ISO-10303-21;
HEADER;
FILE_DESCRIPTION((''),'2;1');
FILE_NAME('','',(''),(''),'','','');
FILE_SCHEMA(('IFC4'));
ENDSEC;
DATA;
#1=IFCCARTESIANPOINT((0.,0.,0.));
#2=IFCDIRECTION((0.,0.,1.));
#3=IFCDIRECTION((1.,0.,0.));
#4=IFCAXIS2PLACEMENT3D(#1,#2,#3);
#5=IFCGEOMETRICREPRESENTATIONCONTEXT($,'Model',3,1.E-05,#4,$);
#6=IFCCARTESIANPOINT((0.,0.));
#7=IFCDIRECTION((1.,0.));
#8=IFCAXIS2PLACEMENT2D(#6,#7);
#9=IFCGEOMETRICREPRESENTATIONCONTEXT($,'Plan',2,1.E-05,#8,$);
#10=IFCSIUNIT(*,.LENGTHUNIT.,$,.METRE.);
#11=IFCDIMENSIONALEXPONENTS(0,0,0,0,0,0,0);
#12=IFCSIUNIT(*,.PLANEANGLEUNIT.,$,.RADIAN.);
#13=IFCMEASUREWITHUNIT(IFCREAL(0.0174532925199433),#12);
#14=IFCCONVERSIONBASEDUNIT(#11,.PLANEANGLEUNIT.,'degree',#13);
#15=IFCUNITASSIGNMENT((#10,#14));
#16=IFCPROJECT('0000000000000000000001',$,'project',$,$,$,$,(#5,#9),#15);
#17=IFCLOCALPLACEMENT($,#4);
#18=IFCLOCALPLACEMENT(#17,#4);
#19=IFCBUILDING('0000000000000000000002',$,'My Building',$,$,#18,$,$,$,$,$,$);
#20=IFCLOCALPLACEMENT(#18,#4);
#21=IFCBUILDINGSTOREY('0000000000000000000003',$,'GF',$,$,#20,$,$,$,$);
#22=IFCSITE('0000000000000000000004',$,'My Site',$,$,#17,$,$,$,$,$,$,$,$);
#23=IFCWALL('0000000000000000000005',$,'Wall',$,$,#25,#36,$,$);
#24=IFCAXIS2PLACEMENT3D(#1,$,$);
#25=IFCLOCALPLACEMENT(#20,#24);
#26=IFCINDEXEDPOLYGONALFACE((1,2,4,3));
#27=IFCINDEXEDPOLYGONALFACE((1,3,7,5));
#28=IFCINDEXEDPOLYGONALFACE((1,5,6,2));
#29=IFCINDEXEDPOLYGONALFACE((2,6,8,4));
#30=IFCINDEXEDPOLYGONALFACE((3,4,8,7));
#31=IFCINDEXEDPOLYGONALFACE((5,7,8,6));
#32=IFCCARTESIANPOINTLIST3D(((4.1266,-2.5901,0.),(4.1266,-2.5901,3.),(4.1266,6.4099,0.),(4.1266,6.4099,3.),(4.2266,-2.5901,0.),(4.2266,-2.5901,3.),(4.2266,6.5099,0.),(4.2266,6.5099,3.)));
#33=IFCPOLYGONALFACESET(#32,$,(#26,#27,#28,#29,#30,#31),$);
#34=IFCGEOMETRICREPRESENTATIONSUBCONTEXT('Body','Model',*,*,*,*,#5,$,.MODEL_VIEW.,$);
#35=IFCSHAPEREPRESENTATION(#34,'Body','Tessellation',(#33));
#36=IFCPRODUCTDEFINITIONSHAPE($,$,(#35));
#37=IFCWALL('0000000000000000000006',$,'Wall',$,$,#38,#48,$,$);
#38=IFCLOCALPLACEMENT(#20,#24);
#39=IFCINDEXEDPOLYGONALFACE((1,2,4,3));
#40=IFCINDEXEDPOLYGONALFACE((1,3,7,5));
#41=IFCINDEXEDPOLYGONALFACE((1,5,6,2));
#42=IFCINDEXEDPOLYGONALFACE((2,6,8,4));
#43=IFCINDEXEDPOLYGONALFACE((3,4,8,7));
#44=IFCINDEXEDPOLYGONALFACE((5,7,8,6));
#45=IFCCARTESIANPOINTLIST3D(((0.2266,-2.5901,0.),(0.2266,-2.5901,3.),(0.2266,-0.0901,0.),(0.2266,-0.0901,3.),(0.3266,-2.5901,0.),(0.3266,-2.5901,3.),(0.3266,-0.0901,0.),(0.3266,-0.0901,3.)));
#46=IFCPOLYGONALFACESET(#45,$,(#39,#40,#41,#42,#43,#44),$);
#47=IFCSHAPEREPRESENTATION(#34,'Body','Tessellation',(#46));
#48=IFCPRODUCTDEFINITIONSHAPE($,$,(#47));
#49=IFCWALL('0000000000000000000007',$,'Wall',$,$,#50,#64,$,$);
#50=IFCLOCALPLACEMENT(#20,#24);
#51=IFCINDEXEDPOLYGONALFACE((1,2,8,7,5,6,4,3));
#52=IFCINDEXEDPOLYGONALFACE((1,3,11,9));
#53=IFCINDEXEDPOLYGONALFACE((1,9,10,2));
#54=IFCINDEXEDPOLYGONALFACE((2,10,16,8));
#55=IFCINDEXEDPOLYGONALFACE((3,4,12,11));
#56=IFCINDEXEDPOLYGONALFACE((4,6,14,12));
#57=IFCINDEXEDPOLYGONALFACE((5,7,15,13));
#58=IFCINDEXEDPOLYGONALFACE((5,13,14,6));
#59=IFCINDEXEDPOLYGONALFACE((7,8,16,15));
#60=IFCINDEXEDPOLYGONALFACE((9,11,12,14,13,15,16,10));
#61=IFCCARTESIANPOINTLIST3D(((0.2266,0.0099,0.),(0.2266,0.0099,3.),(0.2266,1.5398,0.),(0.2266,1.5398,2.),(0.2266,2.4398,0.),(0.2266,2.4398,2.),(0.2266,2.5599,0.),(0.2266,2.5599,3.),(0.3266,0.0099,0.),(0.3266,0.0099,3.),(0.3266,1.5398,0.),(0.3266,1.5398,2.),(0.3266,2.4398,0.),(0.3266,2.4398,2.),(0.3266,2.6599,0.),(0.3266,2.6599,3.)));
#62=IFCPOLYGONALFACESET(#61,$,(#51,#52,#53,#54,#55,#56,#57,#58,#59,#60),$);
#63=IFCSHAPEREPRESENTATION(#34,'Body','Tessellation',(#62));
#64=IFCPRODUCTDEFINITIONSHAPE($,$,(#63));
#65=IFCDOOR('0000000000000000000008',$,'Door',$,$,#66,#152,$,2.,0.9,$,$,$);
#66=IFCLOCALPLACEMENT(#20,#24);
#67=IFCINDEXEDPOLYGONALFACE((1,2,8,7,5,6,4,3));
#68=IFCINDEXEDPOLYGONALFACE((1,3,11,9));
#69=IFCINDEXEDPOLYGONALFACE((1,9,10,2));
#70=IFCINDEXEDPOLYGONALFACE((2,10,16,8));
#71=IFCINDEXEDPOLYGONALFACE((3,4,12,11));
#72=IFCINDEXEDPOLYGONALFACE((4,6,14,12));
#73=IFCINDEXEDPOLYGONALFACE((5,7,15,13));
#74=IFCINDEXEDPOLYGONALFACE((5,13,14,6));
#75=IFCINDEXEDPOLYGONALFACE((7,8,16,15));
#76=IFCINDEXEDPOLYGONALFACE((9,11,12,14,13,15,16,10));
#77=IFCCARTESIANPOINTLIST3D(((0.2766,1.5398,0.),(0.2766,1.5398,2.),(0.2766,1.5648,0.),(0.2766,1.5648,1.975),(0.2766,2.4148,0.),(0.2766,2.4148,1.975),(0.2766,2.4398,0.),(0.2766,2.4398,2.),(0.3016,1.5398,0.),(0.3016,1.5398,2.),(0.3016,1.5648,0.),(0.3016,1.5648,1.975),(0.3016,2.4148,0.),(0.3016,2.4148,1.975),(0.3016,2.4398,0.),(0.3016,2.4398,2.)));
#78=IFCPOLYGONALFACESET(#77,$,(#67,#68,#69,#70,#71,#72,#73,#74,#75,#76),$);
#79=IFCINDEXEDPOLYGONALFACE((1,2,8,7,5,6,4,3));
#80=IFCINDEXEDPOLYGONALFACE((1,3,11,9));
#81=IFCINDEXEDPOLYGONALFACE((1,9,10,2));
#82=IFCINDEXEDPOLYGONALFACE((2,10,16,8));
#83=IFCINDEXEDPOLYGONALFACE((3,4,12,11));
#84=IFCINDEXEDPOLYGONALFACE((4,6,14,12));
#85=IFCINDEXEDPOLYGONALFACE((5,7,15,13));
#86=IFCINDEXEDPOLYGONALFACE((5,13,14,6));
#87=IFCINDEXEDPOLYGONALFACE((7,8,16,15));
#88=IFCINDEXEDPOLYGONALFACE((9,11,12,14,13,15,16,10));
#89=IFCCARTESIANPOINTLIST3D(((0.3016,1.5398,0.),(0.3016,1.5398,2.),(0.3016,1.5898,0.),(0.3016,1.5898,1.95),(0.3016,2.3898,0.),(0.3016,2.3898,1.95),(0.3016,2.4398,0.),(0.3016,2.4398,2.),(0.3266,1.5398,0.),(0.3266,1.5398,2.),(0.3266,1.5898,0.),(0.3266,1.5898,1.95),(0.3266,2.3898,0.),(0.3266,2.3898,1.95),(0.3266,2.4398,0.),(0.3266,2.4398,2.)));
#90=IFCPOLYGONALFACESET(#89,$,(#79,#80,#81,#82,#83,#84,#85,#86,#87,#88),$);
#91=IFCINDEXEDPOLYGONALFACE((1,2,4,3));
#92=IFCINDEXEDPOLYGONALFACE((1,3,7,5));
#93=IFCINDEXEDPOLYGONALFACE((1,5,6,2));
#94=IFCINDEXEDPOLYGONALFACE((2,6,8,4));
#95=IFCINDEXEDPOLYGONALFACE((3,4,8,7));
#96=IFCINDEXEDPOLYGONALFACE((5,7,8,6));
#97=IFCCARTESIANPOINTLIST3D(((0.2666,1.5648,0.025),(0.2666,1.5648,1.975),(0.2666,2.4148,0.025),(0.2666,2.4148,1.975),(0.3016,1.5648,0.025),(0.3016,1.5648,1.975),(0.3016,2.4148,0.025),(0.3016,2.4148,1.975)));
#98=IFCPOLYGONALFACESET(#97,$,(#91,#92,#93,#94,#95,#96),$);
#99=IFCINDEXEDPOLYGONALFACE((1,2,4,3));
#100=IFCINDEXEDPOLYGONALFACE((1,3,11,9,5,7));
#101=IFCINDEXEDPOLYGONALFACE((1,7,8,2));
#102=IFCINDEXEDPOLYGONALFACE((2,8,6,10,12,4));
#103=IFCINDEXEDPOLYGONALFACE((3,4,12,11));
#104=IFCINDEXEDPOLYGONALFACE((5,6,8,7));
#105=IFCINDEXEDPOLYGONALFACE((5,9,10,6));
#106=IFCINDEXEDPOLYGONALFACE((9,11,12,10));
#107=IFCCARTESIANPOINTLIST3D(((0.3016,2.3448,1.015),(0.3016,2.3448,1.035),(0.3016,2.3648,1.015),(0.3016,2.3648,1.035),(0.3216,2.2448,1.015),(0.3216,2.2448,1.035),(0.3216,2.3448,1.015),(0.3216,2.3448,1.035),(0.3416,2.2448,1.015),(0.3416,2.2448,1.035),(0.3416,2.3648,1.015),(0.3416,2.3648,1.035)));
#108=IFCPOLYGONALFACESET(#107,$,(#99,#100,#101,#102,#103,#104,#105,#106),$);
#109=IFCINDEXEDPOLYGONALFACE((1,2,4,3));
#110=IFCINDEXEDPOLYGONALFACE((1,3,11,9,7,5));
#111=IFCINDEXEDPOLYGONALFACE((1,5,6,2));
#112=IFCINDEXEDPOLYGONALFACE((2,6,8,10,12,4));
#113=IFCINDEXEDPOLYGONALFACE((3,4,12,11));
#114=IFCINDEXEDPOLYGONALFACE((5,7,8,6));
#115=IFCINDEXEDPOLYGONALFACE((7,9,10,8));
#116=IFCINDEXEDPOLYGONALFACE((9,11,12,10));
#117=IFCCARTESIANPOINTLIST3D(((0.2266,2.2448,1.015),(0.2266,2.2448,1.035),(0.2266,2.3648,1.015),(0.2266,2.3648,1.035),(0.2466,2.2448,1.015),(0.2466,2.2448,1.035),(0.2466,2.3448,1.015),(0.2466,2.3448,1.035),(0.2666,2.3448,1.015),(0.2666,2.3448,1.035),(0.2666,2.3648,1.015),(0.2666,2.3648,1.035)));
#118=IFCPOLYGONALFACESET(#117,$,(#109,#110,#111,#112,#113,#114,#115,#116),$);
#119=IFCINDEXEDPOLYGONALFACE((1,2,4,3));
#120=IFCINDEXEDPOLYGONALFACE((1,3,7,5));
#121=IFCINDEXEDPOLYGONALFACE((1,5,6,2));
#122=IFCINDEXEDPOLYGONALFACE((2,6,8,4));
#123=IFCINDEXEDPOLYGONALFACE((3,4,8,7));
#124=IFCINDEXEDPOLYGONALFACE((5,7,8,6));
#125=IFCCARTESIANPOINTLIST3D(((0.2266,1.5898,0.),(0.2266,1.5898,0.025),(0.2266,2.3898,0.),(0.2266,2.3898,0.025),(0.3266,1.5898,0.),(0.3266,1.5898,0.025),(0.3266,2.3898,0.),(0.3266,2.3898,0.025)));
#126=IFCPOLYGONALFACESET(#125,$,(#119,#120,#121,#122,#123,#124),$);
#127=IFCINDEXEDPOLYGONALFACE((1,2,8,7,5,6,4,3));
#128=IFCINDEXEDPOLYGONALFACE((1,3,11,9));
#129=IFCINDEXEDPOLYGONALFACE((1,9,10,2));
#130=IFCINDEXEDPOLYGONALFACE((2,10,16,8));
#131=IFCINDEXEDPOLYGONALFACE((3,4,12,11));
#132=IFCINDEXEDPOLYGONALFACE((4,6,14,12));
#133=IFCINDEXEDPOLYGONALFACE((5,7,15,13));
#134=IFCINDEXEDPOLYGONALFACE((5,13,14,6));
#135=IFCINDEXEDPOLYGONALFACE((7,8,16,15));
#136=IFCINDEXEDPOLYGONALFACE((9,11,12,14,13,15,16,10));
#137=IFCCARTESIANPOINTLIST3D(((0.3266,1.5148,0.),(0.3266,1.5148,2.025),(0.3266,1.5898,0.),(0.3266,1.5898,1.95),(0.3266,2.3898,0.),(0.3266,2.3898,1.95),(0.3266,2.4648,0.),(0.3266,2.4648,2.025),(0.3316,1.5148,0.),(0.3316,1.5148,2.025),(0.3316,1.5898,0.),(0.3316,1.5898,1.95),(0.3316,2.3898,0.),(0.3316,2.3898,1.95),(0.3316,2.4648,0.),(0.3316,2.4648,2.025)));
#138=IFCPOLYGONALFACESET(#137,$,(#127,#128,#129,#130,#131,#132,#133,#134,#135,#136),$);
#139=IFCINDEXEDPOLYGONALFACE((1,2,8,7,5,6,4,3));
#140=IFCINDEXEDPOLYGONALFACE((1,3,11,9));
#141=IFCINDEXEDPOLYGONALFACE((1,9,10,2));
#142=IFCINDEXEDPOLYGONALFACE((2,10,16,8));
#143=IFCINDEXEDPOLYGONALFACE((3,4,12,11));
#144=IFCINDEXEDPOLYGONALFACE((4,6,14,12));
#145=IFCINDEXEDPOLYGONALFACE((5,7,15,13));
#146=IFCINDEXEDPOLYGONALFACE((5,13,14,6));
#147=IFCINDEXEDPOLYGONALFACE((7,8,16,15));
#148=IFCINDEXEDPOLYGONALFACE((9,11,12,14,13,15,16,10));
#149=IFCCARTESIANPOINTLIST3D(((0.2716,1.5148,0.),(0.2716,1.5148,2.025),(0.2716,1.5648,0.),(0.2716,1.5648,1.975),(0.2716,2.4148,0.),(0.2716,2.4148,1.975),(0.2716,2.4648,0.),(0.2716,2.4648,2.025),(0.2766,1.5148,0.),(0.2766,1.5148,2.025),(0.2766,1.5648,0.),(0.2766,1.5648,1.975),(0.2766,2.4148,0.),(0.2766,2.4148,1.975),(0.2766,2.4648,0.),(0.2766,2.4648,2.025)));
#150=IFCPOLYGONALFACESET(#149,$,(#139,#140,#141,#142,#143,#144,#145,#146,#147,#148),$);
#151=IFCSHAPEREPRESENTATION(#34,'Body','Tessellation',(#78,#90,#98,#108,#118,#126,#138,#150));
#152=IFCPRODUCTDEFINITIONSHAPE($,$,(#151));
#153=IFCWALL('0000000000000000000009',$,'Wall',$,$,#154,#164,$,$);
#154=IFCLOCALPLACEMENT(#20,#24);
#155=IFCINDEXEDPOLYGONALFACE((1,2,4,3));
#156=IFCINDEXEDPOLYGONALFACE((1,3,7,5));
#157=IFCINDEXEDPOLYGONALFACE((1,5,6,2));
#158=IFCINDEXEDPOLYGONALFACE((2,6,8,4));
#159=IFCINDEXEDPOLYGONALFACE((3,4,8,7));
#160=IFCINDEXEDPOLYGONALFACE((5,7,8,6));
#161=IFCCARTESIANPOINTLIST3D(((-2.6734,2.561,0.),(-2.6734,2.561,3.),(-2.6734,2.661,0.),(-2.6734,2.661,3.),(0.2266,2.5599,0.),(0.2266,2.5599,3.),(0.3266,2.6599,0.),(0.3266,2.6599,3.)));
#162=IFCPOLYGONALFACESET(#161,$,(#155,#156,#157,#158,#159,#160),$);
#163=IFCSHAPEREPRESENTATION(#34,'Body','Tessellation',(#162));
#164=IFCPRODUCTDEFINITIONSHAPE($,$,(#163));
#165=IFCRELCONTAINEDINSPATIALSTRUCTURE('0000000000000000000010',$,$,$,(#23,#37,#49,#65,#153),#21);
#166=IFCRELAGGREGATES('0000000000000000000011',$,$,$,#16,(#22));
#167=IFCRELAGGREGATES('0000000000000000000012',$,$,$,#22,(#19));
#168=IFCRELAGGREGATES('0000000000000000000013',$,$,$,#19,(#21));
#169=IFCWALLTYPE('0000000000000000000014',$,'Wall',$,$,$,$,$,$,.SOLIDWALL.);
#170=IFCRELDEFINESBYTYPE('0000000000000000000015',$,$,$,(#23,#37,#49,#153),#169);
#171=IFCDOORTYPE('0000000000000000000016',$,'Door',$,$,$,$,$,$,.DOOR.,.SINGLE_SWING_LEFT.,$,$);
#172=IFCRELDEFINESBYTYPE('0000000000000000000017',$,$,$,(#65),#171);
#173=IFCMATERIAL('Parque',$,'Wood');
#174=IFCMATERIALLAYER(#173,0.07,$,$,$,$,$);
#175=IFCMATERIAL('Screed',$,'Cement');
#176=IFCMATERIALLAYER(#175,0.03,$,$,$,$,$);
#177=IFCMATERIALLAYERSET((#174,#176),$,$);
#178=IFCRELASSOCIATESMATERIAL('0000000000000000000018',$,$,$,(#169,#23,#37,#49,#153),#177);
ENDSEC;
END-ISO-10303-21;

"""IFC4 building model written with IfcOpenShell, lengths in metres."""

from ifc_helpers import new_model, entity, si_unit, converted_unit, frame, origin_with_axes, origin_2d_with_axis, place, context, subcontext, project, spatial, line, indexed_curve, outline, extrude, shape, source, transform, mapped, material, layer, layer_set, layer_usage, type_object, type_shapes, element, fill, save


model = new_model("IFC4")

# Units and contexts
model_context = context("Model", 3, precision=1e-05, world=origin_with_axes())
plan_context = context("Plan", 2, precision=1e-05, world=origin_2d_with_axis())
body_context_1 = subcontext(model_context, "Body", "Model", "MODEL_VIEW")
body_context_2 = subcontext(plan_context, "Body", "Plan", "PLAN_VIEW")
ifc_project = project(units=[si_unit("LENGTHUNIT", "METRE"), converted_unit("PLANEANGLEUNIT", "degree", entity("IfcReal", 0.0174532925199433), si_unit("PLANEANGLEUNIT", "RADIAN"), dimensions=[0, 0, 0, 0, 0, 0, 0])], contexts=[model_context, plan_context])

# Site, building, storey
site_placement = place(None, origin_with_axes())
site = spatial("IfcSite", under=ifc_project, at=site_placement, Name="My Site")
building_placement = place(site_placement, origin_with_axes())
building = spatial("IfcBuilding", under=site, at=building_placement, Name="My Building")
storey_placement = place(building_placement, origin_with_axes())
storey = spatial("IfcBuildingStorey", under=building, at=storey_placement, Name="GF")

# Shared definitions
ifc_material_1 = material(Name="Parque", Category="Wood")
ifc_layer_1 = layer(ifc_material_1, 0.07)
ifc_material_2 = material(Name="Screed", Category="Cement")
ifc_layer_2 = layer(ifc_material_2, 0.03)
ifc_layer_set_1 = layer_set([ifc_layer_1, ifc_layer_2])
wall_type = type_object("IfcWallType", Name="Wall", PredefinedType="SOLIDWALL", material=ifc_layer_set_1)
shared_shape_1 = source(origin_with_axes(), body_context_1, "Body", "SweptSolid", [
    extrude(outline(indexed_curve([(0.0, 0.0), (0.9, 0.0), (0.9, 2.0), (0.0, 2.0)], segments=[line(1, 2, 3, 4, 1)])), frame((0.0, -0.6, 0.0), z_axis=(0.0, -1.0, 0.0), x_axis=(1.0, 0.0, 0.0)), (0.0, 0.0, -1.0), 1.2),
])
door_type = type_object("IfcDoorType", Name="Door", OperationType="SINGLE_SWING_LEFT", PredefinedType="DOOR")
shared_shape_2 = source(origin_with_axes(), body_context_1, "Body", "SweptSolid", [
    extrude(outline(indexed_curve([(0.0, 0.0), (0.0, 2.0), (0.9, 2.0), (0.9, 0.0), (0.875, 0.0), (0.875, 1.975), (0.025, 1.975), (0.025, 0.0)], segments=[line(1, 2, 3, 4, 5, 6, 7, 8, 1)])), frame((0.0, 0.025, 0.0), z_axis=(0.0, -1.0, 0.0), x_axis=(1.0, 0.0, 0.0)), (0.0, 0.0, -1.0), 0.025),
    extrude(outline(indexed_curve([(0.0, 0.0), (0.0, 2.0), (0.9, 2.0), (0.9, 0.0), (0.85, 0.0), (0.85, 1.95), (0.05, 1.95), (0.05, 0.0)], segments=[line(1, 2, 3, 4, 5, 6, 7, 8, 1)])), frame((0.0, 0.0, 0.0), z_axis=(0.0, -1.0, 0.0), x_axis=(1.0, 0.0, 0.0)), (0.0, 0.0, -1.0), 0.025),
    extrude(outline(indexed_curve([(0.0, 0.0), (0.85, 0.0), (0.85, 0.035), (0.0, 0.035)], segments=[line(1, 2, 3, 4, 1)])), frame((0.025, 0.025, 0.025), z_axis=(0.0, 0.0, 1.0), x_axis=(1.0, 0.0, 0.0)), (0.0, 0.0, 1.0), 1.95),
    extrude(outline(indexed_curve([(0.0, 0.0), (0.0, -0.04), (-0.12, -0.04), (-0.12, -0.02), (-0.02, -0.02), (-0.02, 0.0)], segments=[line(1, 2, 3, 4, 5, 6, 1)])), frame((0.825, 0.025, 1.015), z_axis=(0.0, 0.0, 1.0), x_axis=(1.0, 0.0, 0.0)), (0.0, 0.0, 1.0), 0.02),
    extrude(outline(indexed_curve([(0.0, 0.0), (0.0, 0.04), (-0.12, 0.04), (-0.12, 0.02), (-0.02, 0.02), (-0.02, 0.0)], segments=[line(1, 2, 3, 4, 5, 6, 1)])), frame((0.825, 0.06, 1.015), z_axis=(0.0, 0.0, 1.0), x_axis=(1.0, 0.0, 0.0)), (0.0, 0.0, 1.0), 0.02),
    extrude(outline(indexed_curve([(0.0, 0.0), (0.8, 0.0), (0.8, 0.1), (0.0, 0.1)], segments=[line(1, 2, 3, 4, 1)])), frame((0.05, 0.0, 0.0), z_axis=(0.0, 0.0, 1.0), x_axis=(1.0, 0.0, 0.0)), (0.0, 0.0, 1.0), 0.025),
    extrude(outline(indexed_curve([(0.0, 0.0), (0.0, 2.025), (0.95, 2.025), (0.95, 0.0), (0.875, 0.0), (0.875, 1.95), (0.075, 1.95), (0.075, 0.0)], segments=[line(1, 2, 3, 4, 5, 6, 7, 8, 1)])), frame((-0.025, -0.005, 0.0), z_axis=(0.0, -1.0, 0.0), x_axis=(1.0, 0.0, 0.0)), (0.0, 0.0, -1.0), 0.005),
    extrude(outline(indexed_curve([(0.0, 0.0), (0.0, 2.025), (0.95, 2.025), (0.95, 0.0), (0.9, 0.0), (0.9, 1.975), (0.05, 1.975), (0.05, 0.0)], segments=[line(1, 2, 3, 4, 5, 6, 7, 8, 1)])), frame((-0.025, 0.05, 0.0), z_axis=(0.0, -1.0, 0.0), x_axis=(1.0, 0.0, 0.0)), (0.0, 0.0, -1.0), 0.005),
])
shared_shape_3 = source(origin_with_axes(), body_context_2, "Body", "Curve2D", [
    entity("IfcIndexedPolyCurve", entity("IfcCartesianPointList2D", [[0.0, 0.0], [0.0, 0.05], [0.025, 0.05], [0.025, 0.025], [0.05, 0.025], [0.05, 0.0]]), [entity("IfcLineIndex", [1, 2, 3, 4, 5, 6, 1])]),
    entity("IfcIndexedPolyCurve", entity("IfcCartesianPointList2D", [[0.9, 0.0], [0.9, 0.05], [0.875, 0.05], [0.875, 0.025], [0.85, 0.025], [0.85, 0.0]]), [entity("IfcLineIndex", [1, 2, 3, 4, 5, 6, 1])]),
    entity("IfcTrimmedCurve", entity("IfcEllipse", entity("IfcAxis2Placement2D", entity("IfcCartesianPoint", [0.06, 0.05]), entity("IfcDirection", [1.0, 0.0])), 0.815, 0.85), [entity("IfcCartesianPoint", [0.875, 0.05])], [entity("IfcCartesianPoint", [0.06, 0.9])], True, "CARTESIAN"),
    entity("IfcIndexedPolyCurve", entity("IfcCartesianPointList2D", [[0.025, 0.05], [0.06, 0.05], [0.06, 0.9], [0.025, 0.9]]), [entity("IfcLineIndex", [1, 2, 3, 4, 1])]),
])
type_shapes(door_type, [shared_shape_2, shared_shape_3])

# Walls
ifc_layer_usage_1 = layer_usage(ifc_layer_set_1, "AXIS2", "POSITIVE", 0.0)
wall_1_placement = place(storey_placement, frame((4.2266, -2.5901, 0.0), z_axis=(0.0, 0.0, 1.0), x_axis=(0.0, 1.0, 0.0)))
element("IfcWall", 1, at=wall_1_placement, inside=storey, type_object=wall_type, material=ifc_layer_usage_1, Name="Wall", context=body_context_1, shape_type="SweptSolid", body=[
    extrude(outline(indexed_curve([(0.0, 0.0), (0.0, 0.1), (9.0, 0.1), (9.1, 0.0)], segments=[line(1, 2, 3, 4, 1)])), origin_with_axes(), (0.0, 0.0, 1.0), 3.0),
])
ifc_layer_usage_2 = layer_usage(ifc_layer_set_1, "AXIS2", "POSITIVE", 0.0)
wall_2_placement = place(storey_placement, frame((0.2266, -0.0901, 0.0), z_axis=(0.0, 0.0, 1.0), x_axis=(0.0, -1.0, 0.0)))
element("IfcWall", 2, at=wall_2_placement, inside=storey, type_object=wall_type, material=ifc_layer_usage_2, Name="Wall", context=body_context_1, shape_type="SweptSolid", body=[
    extrude(outline(indexed_curve([(0.0, 0.0), (0.0, 0.1), (2.5, 0.1), (2.5, 0.0)], segments=[line(1, 2, 3, 4, 1)])), origin_with_axes(), (0.0, 0.0, 1.0), 3.0),
])

# Wall, opening, door
ifc_layer_usage_3 = layer_usage(ifc_layer_set_1, "AXIS2", "POSITIVE", 0.0)
wall_3_placement = place(storey_placement, frame((0.3266, 0.0099, 0.0), z_axis=(0.0, 0.0, 1.0), x_axis=(0.0, 1.0, 0.0)))
wall_3 = element("IfcWall", 3, at=wall_3_placement, inside=storey, type_object=wall_type, material=ifc_layer_usage_3, Name="Wall", context=body_context_1, shape_type="SweptSolid", body=[
    extrude(outline(indexed_curve([(0.0, 0.0), (0.0, 0.1), (2.55, 0.1), (2.65, 0.0)], segments=[line(1, 2, 3, 4, 1)])), origin_with_axes(), (0.0, 0.0, 1.0), 3.0),
])
opening_1_placement = place(wall_3_placement, frame((1.5299, 0.0, 0.0), z_axis=(0.0, 0.0, 1.0), x_axis=(1.0, 0.0, 0.0)))
opening_1 = element("IfcOpeningElement", 4, at=opening_1_placement, cuts=wall_3, PredefinedType="OPENING", context=body_context_1, shape_type="MappedRepresentation", body=[
    mapped(shared_shape_1, transform((0.0, 0.0, 0.0), x_axis=(1.0, 0.0, 0.0), y_axis=(0.0, 1.0, 0.0), z_axis=(0.0, 0.0, 1.0), scale=1.0)),
])
door_1_placement = place(opening_1_placement, frame((0.0, 0.0, 0.0), z_axis=(0.0, 0.0, 1.0), x_axis=(1.0, 0.0, 0.0)))
door_1 = element("IfcDoor", 5, at=door_1_placement, inside=storey, type_object=door_type, Name="Door", OverallHeight=2.0, OverallWidth=0.9, shapes=[
    shape(body_context_1, "Body", "MappedRepresentation", [mapped(shared_shape_2, transform((0.0, 0.0, 0.0), x_axis=(1.0, 0.0, 0.0), y_axis=(0.0, 1.0, 0.0), z_axis=(0.0, 0.0, 1.0), scale=1.0))]),
    shape(body_context_2, "Body", "MappedRepresentation", [mapped(shared_shape_3, transform((0.0, 0.0, 0.0), x_axis=(1.0, 0.0, 0.0), y_axis=(0.0, 1.0, 0.0), z_axis=(0.0, 0.0, 1.0), scale=1.0))]),
])
fill(opening_1, door_1)

# Wall
ifc_layer_usage_4 = layer_usage(ifc_layer_set_1, "AXIS2", "POSITIVE", 0.0)
wall_4_placement = place(storey_placement, frame((0.3266, 2.6599, 0.0), z_axis=(0.0, 0.0, 1.0), x_axis=(-1.0, 0.000381, 0.0)))
element("IfcWall", 6, at=wall_4_placement, inside=storey, type_object=wall_type, material=ifc_layer_usage_4, Name="Wall", context=body_context_1, shape_type="SweptSolid", body=[
    extrude(outline(indexed_curve([(0.0, 0.0), (0.1, 0.1), (3.0, 0.1), (3.0, 0.0)], segments=[line(1, 2, 3, 4, 1)])), origin_with_axes(), (0.0, 0.0, 1.0), 3.0),
])

save(model, "model.ifc")
